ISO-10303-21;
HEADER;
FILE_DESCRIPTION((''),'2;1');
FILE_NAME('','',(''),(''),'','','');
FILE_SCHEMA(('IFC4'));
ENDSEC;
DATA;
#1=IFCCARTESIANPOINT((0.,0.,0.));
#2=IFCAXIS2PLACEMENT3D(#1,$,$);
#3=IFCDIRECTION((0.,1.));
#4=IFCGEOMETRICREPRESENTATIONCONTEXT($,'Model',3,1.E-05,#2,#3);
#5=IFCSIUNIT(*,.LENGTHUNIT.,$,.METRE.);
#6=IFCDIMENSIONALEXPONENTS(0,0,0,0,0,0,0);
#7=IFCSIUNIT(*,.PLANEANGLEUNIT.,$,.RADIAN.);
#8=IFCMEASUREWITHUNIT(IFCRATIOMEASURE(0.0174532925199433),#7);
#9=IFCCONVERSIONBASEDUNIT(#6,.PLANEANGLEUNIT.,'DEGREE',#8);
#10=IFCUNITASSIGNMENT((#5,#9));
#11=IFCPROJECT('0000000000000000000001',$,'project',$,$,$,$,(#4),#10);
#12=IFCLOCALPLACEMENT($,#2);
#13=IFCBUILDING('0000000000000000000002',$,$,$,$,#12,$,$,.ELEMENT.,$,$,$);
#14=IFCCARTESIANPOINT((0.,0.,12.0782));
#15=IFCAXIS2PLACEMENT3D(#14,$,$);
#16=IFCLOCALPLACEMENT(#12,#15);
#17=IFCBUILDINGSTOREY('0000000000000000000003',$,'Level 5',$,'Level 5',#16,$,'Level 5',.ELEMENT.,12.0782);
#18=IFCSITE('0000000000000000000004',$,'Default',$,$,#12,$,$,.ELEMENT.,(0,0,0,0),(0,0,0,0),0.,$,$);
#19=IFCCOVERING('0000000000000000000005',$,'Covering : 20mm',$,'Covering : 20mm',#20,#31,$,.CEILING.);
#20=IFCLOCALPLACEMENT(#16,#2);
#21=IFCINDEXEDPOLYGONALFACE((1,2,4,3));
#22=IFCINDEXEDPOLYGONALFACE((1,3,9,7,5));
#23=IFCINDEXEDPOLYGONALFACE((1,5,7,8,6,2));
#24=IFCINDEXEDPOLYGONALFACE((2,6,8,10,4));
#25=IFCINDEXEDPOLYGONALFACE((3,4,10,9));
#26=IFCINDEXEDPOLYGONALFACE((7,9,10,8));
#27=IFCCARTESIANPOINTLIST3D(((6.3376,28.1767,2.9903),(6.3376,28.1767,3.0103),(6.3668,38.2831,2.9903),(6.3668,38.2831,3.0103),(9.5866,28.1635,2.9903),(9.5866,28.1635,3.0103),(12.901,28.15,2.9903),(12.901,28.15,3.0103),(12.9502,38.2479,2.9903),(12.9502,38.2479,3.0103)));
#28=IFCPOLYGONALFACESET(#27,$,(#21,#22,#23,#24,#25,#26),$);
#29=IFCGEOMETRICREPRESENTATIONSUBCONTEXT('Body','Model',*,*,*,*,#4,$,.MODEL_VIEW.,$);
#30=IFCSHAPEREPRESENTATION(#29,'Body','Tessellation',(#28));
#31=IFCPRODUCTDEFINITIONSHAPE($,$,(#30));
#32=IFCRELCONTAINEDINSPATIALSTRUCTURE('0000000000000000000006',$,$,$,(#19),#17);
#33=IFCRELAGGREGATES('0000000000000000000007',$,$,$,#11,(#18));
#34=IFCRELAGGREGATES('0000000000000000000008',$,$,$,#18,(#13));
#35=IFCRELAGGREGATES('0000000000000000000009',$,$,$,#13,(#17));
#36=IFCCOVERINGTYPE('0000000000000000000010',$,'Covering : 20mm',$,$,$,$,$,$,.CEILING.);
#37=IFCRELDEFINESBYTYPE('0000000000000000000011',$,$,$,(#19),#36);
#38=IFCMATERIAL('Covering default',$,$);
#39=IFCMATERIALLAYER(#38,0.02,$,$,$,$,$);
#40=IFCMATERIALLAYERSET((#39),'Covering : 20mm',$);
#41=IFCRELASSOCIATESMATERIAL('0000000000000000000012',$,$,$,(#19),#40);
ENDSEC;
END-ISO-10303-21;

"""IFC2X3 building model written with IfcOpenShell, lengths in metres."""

from ifc_helpers import new_model, entity, si_unit, converted_unit, direction, frame, origin, origin_with_axes, place, context, subcontext, project, spatial, polyline, outline, extrude, material, layer, layer_set, layer_usage, type_object, element, save


model = new_model("IFC2X3")

# Units and contexts
model_context = context("Model", 3, precision=1e-05, world=origin(), true_north=direction((0.0, 1.0)))
body_context = subcontext(model_context, "Body", "Model", "MODEL_VIEW")
ifc_project = project(units=[si_unit("LENGTHUNIT", "METRE"), converted_unit("PLANEANGLEUNIT", "DEGREE", entity("IfcRatioMeasure", 0.0174532925199433), si_unit("PLANEANGLEUNIT", "RADIAN"), dimensions=[0, 0, 0, 0, 0, 0, 0])], contexts=[model_context])

# Site, building, storey
placement_1 = place(None, origin())
site = spatial("IfcSite", under=ifc_project, at=placement_1, Name="Default", CompositionType="ELEMENT", RefLatitude=(0, 0, 0, 0), RefLongitude=(0, 0, 0, 0), RefElevation=0.0)
building = spatial("IfcBuilding", under=site, at=placement_1, CompositionType="ELEMENT")
storey_placement = place(placement_1, frame((0.0, 0.0, 12.0782)))
storey = spatial("IfcBuildingStorey", under=building, at=storey_placement, Name="Level 5", ObjectType="Level 5", LongName="Level 5", CompositionType="ELEMENT", Elevation=12.0782)

# Covering
ifc_material_1 = material(Name="Covering default")
ifc_layer_1 = layer(ifc_material_1, 0.02)
ifc_layer_set_1 = layer_set([ifc_layer_1], Name="Covering : 20mm")
ifc_layer_usage_1 = layer_usage(ifc_layer_set_1, "AXIS3", "POSITIVE", 0.0)
covering_type_1 = type_object("IfcCoveringType", Name="Covering : 20mm", PredefinedType="CEILING")
covering_1_placement = place(placement_1, frame((0.0, 0.0, 15.0685)))
element("IfcCovering", 1, at=covering_1_placement, inside=storey, type_object=covering_type_1, material=ifc_layer_usage_1, Name="Covering : 20mm", ObjectType="Covering : 20mm", PredefinedType="CEILING", context=body_context, shape_type="SweptSolid", body=[
    extrude(outline(polyline([(6.3376, 28.1767), (9.5866, 28.1635), (12.901, 28.15), (12.9502, 38.2479), (6.3668, 38.2831), (6.3376, 28.1767)])), origin_with_axes(), (0.0, 0.0, 1.0), 0.02),
])

save(model, "model.ifc")
